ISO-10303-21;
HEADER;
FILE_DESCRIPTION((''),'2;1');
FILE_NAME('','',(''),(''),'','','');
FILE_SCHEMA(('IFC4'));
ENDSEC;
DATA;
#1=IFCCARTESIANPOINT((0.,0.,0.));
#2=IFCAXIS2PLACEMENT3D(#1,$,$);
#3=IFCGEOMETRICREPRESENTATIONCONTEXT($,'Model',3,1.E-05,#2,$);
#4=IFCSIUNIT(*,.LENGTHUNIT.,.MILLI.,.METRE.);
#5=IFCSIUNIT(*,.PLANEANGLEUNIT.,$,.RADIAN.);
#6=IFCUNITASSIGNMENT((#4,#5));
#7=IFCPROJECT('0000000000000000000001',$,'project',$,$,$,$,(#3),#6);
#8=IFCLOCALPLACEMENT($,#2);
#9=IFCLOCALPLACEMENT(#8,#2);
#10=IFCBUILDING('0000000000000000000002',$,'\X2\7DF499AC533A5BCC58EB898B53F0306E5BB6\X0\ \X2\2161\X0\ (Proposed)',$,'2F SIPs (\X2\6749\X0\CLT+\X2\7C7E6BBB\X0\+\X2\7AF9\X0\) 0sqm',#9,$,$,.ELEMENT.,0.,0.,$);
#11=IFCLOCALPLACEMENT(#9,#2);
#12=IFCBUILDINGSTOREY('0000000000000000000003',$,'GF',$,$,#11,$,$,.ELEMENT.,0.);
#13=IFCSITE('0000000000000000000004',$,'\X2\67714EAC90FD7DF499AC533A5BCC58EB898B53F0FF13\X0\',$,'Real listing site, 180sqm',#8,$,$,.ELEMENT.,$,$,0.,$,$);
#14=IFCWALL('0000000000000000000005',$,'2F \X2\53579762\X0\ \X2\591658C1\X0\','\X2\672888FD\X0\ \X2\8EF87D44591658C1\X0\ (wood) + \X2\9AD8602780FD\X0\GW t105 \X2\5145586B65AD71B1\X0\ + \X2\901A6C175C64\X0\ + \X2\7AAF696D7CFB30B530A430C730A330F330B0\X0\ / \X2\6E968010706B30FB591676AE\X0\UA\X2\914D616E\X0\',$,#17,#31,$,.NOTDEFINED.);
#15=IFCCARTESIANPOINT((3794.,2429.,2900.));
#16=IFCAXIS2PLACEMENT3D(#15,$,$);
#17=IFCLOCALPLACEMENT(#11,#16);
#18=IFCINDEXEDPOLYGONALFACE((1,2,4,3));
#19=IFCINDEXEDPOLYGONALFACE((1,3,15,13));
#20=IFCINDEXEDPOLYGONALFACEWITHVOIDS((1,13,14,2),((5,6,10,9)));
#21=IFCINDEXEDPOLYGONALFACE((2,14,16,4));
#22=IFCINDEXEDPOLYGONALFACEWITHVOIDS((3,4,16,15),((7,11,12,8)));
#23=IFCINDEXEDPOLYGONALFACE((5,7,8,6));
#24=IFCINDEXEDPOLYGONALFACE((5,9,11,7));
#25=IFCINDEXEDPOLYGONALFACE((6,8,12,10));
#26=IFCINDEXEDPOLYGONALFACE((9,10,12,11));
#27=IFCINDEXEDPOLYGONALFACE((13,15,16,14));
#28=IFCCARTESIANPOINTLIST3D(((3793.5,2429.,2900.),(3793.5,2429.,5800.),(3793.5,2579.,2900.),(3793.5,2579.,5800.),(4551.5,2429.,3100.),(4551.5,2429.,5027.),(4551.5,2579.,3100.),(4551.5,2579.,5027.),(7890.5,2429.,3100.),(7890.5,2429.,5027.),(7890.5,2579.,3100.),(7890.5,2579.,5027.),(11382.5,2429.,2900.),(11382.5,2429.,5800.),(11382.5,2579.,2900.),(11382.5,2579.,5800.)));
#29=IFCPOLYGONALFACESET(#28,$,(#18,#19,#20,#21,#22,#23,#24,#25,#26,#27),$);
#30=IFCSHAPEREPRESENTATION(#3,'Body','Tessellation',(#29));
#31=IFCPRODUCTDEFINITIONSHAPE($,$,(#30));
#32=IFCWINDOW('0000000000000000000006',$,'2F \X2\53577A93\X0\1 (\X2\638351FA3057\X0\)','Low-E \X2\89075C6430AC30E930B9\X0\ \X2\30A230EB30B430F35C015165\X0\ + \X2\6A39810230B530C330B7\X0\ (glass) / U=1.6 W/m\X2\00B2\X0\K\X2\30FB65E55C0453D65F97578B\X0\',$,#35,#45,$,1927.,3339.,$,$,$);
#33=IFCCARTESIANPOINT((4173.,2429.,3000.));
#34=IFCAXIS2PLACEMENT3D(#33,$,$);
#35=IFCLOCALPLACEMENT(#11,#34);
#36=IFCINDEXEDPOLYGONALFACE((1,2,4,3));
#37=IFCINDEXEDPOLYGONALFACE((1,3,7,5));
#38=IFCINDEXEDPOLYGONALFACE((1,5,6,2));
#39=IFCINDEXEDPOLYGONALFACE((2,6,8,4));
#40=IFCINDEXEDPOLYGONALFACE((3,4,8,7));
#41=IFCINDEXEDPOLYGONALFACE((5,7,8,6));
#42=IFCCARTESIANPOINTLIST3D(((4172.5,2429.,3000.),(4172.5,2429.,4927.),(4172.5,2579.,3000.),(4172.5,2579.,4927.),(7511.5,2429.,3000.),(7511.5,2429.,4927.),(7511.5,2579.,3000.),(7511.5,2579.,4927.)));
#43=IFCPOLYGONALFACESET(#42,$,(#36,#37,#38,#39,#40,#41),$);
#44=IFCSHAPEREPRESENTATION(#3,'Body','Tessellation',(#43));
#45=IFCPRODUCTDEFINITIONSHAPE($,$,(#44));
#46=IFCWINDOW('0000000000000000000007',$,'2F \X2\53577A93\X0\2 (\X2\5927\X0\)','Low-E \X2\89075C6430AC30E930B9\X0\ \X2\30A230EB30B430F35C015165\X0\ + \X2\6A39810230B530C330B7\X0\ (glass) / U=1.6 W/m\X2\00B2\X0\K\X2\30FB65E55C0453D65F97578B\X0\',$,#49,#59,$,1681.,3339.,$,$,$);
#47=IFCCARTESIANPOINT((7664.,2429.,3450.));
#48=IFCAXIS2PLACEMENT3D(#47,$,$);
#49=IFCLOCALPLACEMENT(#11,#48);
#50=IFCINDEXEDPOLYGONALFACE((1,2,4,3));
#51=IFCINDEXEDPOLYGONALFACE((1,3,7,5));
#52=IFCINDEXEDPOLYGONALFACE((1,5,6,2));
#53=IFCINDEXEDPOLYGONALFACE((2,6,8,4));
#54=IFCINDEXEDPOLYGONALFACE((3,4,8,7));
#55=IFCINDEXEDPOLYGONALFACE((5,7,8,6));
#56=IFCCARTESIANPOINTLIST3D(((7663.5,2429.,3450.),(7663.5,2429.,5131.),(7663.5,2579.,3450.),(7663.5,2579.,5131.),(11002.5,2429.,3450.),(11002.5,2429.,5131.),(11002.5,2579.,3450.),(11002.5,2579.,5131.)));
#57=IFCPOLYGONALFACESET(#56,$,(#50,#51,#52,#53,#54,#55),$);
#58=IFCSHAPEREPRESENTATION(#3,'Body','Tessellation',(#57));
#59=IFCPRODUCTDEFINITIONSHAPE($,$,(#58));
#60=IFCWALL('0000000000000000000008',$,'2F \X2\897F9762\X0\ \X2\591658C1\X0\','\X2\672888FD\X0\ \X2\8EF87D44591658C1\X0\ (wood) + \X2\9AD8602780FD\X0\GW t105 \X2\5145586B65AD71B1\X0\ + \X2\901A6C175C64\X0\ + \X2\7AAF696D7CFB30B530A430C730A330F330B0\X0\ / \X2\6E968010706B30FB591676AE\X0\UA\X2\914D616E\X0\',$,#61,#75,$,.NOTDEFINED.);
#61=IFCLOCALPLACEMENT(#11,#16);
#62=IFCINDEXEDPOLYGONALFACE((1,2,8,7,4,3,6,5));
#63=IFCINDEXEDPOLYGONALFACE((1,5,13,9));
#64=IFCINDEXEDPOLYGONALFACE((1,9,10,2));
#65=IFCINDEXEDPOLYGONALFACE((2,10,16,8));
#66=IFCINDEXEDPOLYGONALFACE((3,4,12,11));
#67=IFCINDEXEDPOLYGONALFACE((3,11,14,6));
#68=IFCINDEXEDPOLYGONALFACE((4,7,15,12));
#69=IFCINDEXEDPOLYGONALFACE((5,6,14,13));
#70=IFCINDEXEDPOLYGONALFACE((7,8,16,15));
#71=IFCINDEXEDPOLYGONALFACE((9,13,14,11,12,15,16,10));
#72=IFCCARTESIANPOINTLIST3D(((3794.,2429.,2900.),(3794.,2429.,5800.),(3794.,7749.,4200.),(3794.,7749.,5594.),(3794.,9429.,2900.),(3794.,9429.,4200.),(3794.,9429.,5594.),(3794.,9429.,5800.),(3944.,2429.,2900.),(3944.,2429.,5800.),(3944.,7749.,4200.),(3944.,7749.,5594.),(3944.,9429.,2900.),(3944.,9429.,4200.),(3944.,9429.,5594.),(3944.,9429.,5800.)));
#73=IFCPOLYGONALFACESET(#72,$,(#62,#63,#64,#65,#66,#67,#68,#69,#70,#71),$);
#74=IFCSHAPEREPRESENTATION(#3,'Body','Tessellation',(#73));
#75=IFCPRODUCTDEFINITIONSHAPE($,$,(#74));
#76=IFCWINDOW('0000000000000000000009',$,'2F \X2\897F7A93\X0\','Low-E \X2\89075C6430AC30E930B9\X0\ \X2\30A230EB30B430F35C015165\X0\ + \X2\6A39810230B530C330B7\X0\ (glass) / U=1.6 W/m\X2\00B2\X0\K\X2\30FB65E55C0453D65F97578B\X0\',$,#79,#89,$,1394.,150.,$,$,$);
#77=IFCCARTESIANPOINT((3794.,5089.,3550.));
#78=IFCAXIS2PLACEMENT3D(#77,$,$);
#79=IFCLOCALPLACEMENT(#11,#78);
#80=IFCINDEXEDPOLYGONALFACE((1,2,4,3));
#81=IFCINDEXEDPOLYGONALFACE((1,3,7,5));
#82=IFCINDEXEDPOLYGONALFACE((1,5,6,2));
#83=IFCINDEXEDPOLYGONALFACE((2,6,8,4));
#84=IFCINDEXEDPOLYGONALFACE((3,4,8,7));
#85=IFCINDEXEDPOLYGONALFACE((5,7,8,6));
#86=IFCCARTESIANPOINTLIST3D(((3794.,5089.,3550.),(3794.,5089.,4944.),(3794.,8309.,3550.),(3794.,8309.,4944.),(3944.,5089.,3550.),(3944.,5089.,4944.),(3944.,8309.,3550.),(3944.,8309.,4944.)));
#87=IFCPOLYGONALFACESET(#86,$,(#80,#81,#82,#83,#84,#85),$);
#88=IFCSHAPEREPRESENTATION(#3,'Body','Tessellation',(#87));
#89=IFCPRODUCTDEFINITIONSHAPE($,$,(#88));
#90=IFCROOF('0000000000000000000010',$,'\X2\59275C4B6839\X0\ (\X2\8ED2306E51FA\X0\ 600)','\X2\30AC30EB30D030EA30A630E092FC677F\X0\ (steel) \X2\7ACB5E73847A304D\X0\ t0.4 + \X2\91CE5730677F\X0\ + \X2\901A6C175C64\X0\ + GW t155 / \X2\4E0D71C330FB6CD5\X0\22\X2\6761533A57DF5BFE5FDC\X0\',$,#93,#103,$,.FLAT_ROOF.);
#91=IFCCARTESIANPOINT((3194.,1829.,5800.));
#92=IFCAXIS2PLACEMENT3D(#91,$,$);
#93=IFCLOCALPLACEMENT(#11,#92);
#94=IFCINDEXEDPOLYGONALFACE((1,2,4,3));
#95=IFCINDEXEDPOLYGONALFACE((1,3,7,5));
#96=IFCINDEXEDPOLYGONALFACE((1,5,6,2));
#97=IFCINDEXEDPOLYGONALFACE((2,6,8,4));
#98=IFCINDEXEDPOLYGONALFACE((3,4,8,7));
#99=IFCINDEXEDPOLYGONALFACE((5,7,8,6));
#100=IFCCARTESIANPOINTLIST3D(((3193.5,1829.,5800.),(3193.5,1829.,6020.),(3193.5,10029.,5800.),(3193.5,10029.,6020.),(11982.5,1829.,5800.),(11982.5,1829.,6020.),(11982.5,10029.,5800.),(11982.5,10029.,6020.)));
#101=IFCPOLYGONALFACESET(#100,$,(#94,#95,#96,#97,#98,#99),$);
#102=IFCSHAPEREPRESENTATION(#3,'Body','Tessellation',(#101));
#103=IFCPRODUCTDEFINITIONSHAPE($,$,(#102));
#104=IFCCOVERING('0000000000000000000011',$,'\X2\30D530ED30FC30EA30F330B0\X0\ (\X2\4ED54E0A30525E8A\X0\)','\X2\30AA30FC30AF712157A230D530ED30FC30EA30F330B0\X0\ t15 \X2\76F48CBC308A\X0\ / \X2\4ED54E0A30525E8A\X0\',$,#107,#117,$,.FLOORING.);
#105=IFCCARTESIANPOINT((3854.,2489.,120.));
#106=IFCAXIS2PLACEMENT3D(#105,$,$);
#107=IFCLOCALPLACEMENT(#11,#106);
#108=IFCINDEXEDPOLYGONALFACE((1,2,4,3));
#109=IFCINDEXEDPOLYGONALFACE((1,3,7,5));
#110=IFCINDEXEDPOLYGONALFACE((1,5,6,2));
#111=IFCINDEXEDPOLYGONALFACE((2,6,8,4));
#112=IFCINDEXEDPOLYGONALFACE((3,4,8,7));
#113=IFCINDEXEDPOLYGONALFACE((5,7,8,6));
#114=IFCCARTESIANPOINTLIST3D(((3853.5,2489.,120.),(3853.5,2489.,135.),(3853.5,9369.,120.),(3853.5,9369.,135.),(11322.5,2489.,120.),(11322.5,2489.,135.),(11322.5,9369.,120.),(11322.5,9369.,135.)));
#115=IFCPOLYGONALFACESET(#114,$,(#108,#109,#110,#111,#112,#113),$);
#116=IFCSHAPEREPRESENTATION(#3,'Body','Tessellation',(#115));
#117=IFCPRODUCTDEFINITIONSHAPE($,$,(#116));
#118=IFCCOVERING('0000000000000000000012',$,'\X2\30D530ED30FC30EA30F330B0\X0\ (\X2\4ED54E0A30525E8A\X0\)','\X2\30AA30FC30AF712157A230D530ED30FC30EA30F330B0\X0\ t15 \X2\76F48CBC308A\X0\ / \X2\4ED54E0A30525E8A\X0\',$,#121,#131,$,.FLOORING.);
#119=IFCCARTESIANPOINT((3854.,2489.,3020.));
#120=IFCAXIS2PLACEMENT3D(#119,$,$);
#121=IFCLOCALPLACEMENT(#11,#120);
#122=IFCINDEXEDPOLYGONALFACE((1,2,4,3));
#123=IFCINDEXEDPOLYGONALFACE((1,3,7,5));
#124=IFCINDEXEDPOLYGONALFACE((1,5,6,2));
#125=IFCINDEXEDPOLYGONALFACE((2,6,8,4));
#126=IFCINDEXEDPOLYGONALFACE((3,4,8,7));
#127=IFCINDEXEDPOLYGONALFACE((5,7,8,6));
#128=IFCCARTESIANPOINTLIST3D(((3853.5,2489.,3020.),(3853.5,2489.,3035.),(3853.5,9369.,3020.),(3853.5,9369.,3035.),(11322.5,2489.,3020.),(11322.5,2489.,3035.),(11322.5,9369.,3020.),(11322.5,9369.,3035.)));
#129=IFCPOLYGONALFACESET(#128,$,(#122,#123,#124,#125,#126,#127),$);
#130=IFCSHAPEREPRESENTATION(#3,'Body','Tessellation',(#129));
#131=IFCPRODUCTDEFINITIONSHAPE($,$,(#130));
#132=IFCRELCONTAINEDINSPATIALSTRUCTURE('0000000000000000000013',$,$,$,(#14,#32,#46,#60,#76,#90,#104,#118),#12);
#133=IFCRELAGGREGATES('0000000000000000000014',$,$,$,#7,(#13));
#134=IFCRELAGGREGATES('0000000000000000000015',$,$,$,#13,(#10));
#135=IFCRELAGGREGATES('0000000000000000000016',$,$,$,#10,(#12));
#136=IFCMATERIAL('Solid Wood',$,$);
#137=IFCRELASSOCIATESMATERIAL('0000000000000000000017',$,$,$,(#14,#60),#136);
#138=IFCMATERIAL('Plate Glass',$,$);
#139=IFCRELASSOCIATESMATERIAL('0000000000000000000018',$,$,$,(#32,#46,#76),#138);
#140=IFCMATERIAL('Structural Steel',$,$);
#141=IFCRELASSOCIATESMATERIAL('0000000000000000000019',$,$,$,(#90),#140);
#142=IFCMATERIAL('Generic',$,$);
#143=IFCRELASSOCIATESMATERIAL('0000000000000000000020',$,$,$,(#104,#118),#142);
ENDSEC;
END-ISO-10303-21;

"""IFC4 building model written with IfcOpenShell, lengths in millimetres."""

from ifc_helpers import new_model, si_unit, frame, frame_2d, origin, place, context, project, spatial, rectangle, extrude, material, element, fill, save


model = new_model("IFC4")

# Units and contexts
model_context = context("Model", 3, precision=1e-05, world=origin())
ifc_project = project(units=[si_unit("LENGTHUNIT", "METRE", prefix="MILLI"), si_unit("PLANEANGLEUNIT", "RADIAN")], contexts=[model_context])

# Site, building, storey
site_placement = place(None, origin())
site = spatial("IfcSite", under=ifc_project, at=site_placement, Name="東京都練馬区富士見台３", ObjectType="Real listing site, 180sqm", CompositionType="ELEMENT", RefElevation=0.0)
building_placement = place(site_placement, origin())
building = spatial("IfcBuilding", under=site, at=building_placement, Name="練馬区富士見台の家 Ⅱ (Proposed)", ObjectType="2F SIPs (杉CLT+籾殻+竹) 0sqm", CompositionType="ELEMENT", ElevationOfRefHeight=0.0, ElevationOfTerrain=0.0)
storey_placement = place(building_placement, origin())
storey = spatial("IfcBuildingStorey", under=building, at=storey_placement, Name="GF", CompositionType="ELEMENT", Elevation=0.0)

# Shared definitions
ifc_material_1 = material(Name="Solid Wood")

# Shared definitions
ifc_material_2 = material(Name="Plate Glass")

# Wall, openings, windows
wall_1_placement = place(storey_placement, frame((3794.0, 2429.0, 2900.0)))
wall_1 = element("IfcWall", 1, at=wall_1_placement, inside=storey, material=ifc_material_1, Name="2F 南面 外壁", Description="木製 軸組外壁 (wood) + 高性能GW t105 充填断熱 + 通気層 + 窯業系サイディング / 準耐火・外皮UA配慮", PredefinedType="NOTDEFINED", context=model_context, shape_type="SweptSolid", body=[
    extrude(rectangle(XDim=7589.0, YDim=150.0, at=frame_2d((3794.0, 75.0))), frame((3794.0, 2429.0, 2900.0)), (0.0, 0.0, 1.0), 2900.0),
])
opening_1_placement = place(storey_placement, frame((4173.0, 2429.0, 3000.0)))
opening_1 = element("IfcOpeningElement", 2, at=opening_1_placement, cuts=wall_1, PredefinedType="NOTDEFINED", context=model_context, shape_type="SweptSolid", body=[
    extrude(rectangle(XDim=3339.0, YDim=150.0, at=frame_2d((1669.0, 75.0))), frame((4173.0, 2429.0, 3000.0)), (0.0, 0.0, 1.0), 1927.0),
])
opening_2_placement = place(storey_placement, frame((7664.0, 2429.0, 3450.0)))
opening_2 = element("IfcOpeningElement", 3, at=opening_2_placement, cuts=wall_1, PredefinedType="NOTDEFINED", context=model_context, shape_type="SweptSolid", body=[
    extrude(rectangle(XDim=3339.0, YDim=150.0, at=frame_2d((1669.0, 75.0))), frame((7664.0, 2429.0, 3450.0)), (0.0, 0.0, 1.0), 1681.0),
])
window_1_placement = place(storey_placement, frame((4173.0, 2429.0, 3000.0)))
window_1 = element("IfcWindow", 4, at=window_1_placement, inside=storey, material=ifc_material_2, Name="2F 南窓1 (掃出し)", Description="Low-E 複層ガラス アルゴン封入 + 樹脂サッシ (glass) / U=1.6 W/m²K・日射取得型", OverallHeight=1927.0, OverallWidth=3339.0, context=model_context, shape_type="SweptSolid", body=[
    extrude(rectangle(XDim=3339.0, YDim=150.0, at=frame_2d((1669.0, 75.0))), frame((4173.0, 2429.0, 3000.0)), (0.0, 0.0, 1.0), 1927.0),
])
fill(opening_1, window_1)
window_2_placement = place(storey_placement, frame((7664.0, 2429.0, 3450.0)))
window_2 = element("IfcWindow", 5, at=window_2_placement, inside=storey, material=ifc_material_2, Name="2F 南窓2 (大)", Description="Low-E 複層ガラス アルゴン封入 + 樹脂サッシ (glass) / U=1.6 W/m²K・日射取得型", OverallHeight=1681.0, OverallWidth=3339.0, context=model_context, shape_type="SweptSolid", body=[
    extrude(rectangle(XDim=3339.0, YDim=150.0, at=frame_2d((1669.0, 75.0))), frame((7664.0, 2429.0, 3450.0)), (0.0, 0.0, 1.0), 1681.0),
])
fill(opening_2, window_2)

# Wall, opening, window
wall_2_placement = place(storey_placement, frame((3794.0, 2429.0, 2900.0)))
wall_2 = element("IfcWall", 6, at=wall_2_placement, inside=storey, material=ifc_material_1, Name="2F 西面 外壁", Description="木製 軸組外壁 (wood) + 高性能GW t105 充填断熱 + 通気層 + 窯業系サイディング / 準耐火・外皮UA配慮", PredefinedType="NOTDEFINED", context=model_context, shape_type="SweptSolid", body=[
    extrude(rectangle(XDim=150.0, YDim=7000.0, at=frame_2d((75.0, 3500.0))), frame((3794.0, 2429.0, 2900.0)), (0.0, 0.0, 1.0), 2900.0),
])
opening_3_placement = place(storey_placement, frame((3794.0, 5089.0, 3550.0)))
opening_3 = element("IfcOpeningElement", 7, at=opening_3_placement, cuts=wall_2, PredefinedType="NOTDEFINED", context=model_context, shape_type="SweptSolid", body=[
    extrude(rectangle(XDim=150.0, YDim=3220.0, at=frame_2d((75.0, 1610.0))), frame((3794.0, 5089.0, 3550.0)), (0.0, 0.0, 1.0), 1394.0),
])
window_3_placement = place(storey_placement, frame((3794.0, 5089.0, 3550.0)))
window_3 = element("IfcWindow", 8, at=window_3_placement, inside=storey, material=ifc_material_2, Name="2F 西窓", Description="Low-E 複層ガラス アルゴン封入 + 樹脂サッシ (glass) / U=1.6 W/m²K・日射取得型", OverallHeight=1394.0, OverallWidth=150.0, context=model_context, shape_type="SweptSolid", body=[
    extrude(rectangle(XDim=150.0, YDim=3220.0, at=frame_2d((75.0, 1610.0))), frame((3794.0, 5089.0, 3550.0)), (0.0, 0.0, 1.0), 1394.0),
])
fill(opening_3, window_3)

# Roof
ifc_material_3 = material(Name="Structural Steel")
roof_placement = place(storey_placement, frame((3194.0, 1829.0, 5800.0)))
element("IfcRoof", 9, at=roof_placement, inside=storey, material=ifc_material_3, Name="大屋根 (軒の出 600)", Description="ガルバリウム鋼板 (steel) 立平葺き t0.4 + 野地板 + 通気層 + GW t155 / 不燃・法22条区域対応", PredefinedType="FLAT_ROOF", context=model_context, shape_type="SweptSolid", body=[
    extrude(rectangle(XDim=8789.0, YDim=8200.0, at=frame_2d((4394.0, 4100.0))), frame((3194.0, 1829.0, 5800.0)), (0.0, 0.0, 1.0), 220.0),
])

# Coverings
ifc_material_4 = material(Name="Generic")
covering_1_placement = place(storey_placement, frame((3854.0, 2489.0, 120.0)))
element("IfcCovering", 10, at=covering_1_placement, inside=storey, material=ifc_material_4, Name="フローリング (仕上げ床)", Description="オーク無垢フローリング t15 直貼り / 仕上げ床", PredefinedType="FLOORING", context=model_context, shape_type="SweptSolid", body=[
    extrude(rectangle(XDim=7469.0, YDim=6880.0, at=frame_2d((3734.0, 3440.0))), frame((3854.0, 2489.0, 120.0)), (0.0, 0.0, 1.0), 15.0),
])
covering_2_placement = place(storey_placement, frame((3854.0, 2489.0, 3020.0)))
element("IfcCovering", 11, at=covering_2_placement, inside=storey, material=ifc_material_4, Name="フローリング (仕上げ床)", Description="オーク無垢フローリング t15 直貼り / 仕上げ床", PredefinedType="FLOORING", context=model_context, shape_type="SweptSolid", body=[
    extrude(rectangle(XDim=7469.0, YDim=6880.0, at=frame_2d((3734.0, 3440.0))), frame((3854.0, 2489.0, 3020.0)), (0.0, 0.0, 1.0), 15.0),
])

save(model, "model.ifc")
